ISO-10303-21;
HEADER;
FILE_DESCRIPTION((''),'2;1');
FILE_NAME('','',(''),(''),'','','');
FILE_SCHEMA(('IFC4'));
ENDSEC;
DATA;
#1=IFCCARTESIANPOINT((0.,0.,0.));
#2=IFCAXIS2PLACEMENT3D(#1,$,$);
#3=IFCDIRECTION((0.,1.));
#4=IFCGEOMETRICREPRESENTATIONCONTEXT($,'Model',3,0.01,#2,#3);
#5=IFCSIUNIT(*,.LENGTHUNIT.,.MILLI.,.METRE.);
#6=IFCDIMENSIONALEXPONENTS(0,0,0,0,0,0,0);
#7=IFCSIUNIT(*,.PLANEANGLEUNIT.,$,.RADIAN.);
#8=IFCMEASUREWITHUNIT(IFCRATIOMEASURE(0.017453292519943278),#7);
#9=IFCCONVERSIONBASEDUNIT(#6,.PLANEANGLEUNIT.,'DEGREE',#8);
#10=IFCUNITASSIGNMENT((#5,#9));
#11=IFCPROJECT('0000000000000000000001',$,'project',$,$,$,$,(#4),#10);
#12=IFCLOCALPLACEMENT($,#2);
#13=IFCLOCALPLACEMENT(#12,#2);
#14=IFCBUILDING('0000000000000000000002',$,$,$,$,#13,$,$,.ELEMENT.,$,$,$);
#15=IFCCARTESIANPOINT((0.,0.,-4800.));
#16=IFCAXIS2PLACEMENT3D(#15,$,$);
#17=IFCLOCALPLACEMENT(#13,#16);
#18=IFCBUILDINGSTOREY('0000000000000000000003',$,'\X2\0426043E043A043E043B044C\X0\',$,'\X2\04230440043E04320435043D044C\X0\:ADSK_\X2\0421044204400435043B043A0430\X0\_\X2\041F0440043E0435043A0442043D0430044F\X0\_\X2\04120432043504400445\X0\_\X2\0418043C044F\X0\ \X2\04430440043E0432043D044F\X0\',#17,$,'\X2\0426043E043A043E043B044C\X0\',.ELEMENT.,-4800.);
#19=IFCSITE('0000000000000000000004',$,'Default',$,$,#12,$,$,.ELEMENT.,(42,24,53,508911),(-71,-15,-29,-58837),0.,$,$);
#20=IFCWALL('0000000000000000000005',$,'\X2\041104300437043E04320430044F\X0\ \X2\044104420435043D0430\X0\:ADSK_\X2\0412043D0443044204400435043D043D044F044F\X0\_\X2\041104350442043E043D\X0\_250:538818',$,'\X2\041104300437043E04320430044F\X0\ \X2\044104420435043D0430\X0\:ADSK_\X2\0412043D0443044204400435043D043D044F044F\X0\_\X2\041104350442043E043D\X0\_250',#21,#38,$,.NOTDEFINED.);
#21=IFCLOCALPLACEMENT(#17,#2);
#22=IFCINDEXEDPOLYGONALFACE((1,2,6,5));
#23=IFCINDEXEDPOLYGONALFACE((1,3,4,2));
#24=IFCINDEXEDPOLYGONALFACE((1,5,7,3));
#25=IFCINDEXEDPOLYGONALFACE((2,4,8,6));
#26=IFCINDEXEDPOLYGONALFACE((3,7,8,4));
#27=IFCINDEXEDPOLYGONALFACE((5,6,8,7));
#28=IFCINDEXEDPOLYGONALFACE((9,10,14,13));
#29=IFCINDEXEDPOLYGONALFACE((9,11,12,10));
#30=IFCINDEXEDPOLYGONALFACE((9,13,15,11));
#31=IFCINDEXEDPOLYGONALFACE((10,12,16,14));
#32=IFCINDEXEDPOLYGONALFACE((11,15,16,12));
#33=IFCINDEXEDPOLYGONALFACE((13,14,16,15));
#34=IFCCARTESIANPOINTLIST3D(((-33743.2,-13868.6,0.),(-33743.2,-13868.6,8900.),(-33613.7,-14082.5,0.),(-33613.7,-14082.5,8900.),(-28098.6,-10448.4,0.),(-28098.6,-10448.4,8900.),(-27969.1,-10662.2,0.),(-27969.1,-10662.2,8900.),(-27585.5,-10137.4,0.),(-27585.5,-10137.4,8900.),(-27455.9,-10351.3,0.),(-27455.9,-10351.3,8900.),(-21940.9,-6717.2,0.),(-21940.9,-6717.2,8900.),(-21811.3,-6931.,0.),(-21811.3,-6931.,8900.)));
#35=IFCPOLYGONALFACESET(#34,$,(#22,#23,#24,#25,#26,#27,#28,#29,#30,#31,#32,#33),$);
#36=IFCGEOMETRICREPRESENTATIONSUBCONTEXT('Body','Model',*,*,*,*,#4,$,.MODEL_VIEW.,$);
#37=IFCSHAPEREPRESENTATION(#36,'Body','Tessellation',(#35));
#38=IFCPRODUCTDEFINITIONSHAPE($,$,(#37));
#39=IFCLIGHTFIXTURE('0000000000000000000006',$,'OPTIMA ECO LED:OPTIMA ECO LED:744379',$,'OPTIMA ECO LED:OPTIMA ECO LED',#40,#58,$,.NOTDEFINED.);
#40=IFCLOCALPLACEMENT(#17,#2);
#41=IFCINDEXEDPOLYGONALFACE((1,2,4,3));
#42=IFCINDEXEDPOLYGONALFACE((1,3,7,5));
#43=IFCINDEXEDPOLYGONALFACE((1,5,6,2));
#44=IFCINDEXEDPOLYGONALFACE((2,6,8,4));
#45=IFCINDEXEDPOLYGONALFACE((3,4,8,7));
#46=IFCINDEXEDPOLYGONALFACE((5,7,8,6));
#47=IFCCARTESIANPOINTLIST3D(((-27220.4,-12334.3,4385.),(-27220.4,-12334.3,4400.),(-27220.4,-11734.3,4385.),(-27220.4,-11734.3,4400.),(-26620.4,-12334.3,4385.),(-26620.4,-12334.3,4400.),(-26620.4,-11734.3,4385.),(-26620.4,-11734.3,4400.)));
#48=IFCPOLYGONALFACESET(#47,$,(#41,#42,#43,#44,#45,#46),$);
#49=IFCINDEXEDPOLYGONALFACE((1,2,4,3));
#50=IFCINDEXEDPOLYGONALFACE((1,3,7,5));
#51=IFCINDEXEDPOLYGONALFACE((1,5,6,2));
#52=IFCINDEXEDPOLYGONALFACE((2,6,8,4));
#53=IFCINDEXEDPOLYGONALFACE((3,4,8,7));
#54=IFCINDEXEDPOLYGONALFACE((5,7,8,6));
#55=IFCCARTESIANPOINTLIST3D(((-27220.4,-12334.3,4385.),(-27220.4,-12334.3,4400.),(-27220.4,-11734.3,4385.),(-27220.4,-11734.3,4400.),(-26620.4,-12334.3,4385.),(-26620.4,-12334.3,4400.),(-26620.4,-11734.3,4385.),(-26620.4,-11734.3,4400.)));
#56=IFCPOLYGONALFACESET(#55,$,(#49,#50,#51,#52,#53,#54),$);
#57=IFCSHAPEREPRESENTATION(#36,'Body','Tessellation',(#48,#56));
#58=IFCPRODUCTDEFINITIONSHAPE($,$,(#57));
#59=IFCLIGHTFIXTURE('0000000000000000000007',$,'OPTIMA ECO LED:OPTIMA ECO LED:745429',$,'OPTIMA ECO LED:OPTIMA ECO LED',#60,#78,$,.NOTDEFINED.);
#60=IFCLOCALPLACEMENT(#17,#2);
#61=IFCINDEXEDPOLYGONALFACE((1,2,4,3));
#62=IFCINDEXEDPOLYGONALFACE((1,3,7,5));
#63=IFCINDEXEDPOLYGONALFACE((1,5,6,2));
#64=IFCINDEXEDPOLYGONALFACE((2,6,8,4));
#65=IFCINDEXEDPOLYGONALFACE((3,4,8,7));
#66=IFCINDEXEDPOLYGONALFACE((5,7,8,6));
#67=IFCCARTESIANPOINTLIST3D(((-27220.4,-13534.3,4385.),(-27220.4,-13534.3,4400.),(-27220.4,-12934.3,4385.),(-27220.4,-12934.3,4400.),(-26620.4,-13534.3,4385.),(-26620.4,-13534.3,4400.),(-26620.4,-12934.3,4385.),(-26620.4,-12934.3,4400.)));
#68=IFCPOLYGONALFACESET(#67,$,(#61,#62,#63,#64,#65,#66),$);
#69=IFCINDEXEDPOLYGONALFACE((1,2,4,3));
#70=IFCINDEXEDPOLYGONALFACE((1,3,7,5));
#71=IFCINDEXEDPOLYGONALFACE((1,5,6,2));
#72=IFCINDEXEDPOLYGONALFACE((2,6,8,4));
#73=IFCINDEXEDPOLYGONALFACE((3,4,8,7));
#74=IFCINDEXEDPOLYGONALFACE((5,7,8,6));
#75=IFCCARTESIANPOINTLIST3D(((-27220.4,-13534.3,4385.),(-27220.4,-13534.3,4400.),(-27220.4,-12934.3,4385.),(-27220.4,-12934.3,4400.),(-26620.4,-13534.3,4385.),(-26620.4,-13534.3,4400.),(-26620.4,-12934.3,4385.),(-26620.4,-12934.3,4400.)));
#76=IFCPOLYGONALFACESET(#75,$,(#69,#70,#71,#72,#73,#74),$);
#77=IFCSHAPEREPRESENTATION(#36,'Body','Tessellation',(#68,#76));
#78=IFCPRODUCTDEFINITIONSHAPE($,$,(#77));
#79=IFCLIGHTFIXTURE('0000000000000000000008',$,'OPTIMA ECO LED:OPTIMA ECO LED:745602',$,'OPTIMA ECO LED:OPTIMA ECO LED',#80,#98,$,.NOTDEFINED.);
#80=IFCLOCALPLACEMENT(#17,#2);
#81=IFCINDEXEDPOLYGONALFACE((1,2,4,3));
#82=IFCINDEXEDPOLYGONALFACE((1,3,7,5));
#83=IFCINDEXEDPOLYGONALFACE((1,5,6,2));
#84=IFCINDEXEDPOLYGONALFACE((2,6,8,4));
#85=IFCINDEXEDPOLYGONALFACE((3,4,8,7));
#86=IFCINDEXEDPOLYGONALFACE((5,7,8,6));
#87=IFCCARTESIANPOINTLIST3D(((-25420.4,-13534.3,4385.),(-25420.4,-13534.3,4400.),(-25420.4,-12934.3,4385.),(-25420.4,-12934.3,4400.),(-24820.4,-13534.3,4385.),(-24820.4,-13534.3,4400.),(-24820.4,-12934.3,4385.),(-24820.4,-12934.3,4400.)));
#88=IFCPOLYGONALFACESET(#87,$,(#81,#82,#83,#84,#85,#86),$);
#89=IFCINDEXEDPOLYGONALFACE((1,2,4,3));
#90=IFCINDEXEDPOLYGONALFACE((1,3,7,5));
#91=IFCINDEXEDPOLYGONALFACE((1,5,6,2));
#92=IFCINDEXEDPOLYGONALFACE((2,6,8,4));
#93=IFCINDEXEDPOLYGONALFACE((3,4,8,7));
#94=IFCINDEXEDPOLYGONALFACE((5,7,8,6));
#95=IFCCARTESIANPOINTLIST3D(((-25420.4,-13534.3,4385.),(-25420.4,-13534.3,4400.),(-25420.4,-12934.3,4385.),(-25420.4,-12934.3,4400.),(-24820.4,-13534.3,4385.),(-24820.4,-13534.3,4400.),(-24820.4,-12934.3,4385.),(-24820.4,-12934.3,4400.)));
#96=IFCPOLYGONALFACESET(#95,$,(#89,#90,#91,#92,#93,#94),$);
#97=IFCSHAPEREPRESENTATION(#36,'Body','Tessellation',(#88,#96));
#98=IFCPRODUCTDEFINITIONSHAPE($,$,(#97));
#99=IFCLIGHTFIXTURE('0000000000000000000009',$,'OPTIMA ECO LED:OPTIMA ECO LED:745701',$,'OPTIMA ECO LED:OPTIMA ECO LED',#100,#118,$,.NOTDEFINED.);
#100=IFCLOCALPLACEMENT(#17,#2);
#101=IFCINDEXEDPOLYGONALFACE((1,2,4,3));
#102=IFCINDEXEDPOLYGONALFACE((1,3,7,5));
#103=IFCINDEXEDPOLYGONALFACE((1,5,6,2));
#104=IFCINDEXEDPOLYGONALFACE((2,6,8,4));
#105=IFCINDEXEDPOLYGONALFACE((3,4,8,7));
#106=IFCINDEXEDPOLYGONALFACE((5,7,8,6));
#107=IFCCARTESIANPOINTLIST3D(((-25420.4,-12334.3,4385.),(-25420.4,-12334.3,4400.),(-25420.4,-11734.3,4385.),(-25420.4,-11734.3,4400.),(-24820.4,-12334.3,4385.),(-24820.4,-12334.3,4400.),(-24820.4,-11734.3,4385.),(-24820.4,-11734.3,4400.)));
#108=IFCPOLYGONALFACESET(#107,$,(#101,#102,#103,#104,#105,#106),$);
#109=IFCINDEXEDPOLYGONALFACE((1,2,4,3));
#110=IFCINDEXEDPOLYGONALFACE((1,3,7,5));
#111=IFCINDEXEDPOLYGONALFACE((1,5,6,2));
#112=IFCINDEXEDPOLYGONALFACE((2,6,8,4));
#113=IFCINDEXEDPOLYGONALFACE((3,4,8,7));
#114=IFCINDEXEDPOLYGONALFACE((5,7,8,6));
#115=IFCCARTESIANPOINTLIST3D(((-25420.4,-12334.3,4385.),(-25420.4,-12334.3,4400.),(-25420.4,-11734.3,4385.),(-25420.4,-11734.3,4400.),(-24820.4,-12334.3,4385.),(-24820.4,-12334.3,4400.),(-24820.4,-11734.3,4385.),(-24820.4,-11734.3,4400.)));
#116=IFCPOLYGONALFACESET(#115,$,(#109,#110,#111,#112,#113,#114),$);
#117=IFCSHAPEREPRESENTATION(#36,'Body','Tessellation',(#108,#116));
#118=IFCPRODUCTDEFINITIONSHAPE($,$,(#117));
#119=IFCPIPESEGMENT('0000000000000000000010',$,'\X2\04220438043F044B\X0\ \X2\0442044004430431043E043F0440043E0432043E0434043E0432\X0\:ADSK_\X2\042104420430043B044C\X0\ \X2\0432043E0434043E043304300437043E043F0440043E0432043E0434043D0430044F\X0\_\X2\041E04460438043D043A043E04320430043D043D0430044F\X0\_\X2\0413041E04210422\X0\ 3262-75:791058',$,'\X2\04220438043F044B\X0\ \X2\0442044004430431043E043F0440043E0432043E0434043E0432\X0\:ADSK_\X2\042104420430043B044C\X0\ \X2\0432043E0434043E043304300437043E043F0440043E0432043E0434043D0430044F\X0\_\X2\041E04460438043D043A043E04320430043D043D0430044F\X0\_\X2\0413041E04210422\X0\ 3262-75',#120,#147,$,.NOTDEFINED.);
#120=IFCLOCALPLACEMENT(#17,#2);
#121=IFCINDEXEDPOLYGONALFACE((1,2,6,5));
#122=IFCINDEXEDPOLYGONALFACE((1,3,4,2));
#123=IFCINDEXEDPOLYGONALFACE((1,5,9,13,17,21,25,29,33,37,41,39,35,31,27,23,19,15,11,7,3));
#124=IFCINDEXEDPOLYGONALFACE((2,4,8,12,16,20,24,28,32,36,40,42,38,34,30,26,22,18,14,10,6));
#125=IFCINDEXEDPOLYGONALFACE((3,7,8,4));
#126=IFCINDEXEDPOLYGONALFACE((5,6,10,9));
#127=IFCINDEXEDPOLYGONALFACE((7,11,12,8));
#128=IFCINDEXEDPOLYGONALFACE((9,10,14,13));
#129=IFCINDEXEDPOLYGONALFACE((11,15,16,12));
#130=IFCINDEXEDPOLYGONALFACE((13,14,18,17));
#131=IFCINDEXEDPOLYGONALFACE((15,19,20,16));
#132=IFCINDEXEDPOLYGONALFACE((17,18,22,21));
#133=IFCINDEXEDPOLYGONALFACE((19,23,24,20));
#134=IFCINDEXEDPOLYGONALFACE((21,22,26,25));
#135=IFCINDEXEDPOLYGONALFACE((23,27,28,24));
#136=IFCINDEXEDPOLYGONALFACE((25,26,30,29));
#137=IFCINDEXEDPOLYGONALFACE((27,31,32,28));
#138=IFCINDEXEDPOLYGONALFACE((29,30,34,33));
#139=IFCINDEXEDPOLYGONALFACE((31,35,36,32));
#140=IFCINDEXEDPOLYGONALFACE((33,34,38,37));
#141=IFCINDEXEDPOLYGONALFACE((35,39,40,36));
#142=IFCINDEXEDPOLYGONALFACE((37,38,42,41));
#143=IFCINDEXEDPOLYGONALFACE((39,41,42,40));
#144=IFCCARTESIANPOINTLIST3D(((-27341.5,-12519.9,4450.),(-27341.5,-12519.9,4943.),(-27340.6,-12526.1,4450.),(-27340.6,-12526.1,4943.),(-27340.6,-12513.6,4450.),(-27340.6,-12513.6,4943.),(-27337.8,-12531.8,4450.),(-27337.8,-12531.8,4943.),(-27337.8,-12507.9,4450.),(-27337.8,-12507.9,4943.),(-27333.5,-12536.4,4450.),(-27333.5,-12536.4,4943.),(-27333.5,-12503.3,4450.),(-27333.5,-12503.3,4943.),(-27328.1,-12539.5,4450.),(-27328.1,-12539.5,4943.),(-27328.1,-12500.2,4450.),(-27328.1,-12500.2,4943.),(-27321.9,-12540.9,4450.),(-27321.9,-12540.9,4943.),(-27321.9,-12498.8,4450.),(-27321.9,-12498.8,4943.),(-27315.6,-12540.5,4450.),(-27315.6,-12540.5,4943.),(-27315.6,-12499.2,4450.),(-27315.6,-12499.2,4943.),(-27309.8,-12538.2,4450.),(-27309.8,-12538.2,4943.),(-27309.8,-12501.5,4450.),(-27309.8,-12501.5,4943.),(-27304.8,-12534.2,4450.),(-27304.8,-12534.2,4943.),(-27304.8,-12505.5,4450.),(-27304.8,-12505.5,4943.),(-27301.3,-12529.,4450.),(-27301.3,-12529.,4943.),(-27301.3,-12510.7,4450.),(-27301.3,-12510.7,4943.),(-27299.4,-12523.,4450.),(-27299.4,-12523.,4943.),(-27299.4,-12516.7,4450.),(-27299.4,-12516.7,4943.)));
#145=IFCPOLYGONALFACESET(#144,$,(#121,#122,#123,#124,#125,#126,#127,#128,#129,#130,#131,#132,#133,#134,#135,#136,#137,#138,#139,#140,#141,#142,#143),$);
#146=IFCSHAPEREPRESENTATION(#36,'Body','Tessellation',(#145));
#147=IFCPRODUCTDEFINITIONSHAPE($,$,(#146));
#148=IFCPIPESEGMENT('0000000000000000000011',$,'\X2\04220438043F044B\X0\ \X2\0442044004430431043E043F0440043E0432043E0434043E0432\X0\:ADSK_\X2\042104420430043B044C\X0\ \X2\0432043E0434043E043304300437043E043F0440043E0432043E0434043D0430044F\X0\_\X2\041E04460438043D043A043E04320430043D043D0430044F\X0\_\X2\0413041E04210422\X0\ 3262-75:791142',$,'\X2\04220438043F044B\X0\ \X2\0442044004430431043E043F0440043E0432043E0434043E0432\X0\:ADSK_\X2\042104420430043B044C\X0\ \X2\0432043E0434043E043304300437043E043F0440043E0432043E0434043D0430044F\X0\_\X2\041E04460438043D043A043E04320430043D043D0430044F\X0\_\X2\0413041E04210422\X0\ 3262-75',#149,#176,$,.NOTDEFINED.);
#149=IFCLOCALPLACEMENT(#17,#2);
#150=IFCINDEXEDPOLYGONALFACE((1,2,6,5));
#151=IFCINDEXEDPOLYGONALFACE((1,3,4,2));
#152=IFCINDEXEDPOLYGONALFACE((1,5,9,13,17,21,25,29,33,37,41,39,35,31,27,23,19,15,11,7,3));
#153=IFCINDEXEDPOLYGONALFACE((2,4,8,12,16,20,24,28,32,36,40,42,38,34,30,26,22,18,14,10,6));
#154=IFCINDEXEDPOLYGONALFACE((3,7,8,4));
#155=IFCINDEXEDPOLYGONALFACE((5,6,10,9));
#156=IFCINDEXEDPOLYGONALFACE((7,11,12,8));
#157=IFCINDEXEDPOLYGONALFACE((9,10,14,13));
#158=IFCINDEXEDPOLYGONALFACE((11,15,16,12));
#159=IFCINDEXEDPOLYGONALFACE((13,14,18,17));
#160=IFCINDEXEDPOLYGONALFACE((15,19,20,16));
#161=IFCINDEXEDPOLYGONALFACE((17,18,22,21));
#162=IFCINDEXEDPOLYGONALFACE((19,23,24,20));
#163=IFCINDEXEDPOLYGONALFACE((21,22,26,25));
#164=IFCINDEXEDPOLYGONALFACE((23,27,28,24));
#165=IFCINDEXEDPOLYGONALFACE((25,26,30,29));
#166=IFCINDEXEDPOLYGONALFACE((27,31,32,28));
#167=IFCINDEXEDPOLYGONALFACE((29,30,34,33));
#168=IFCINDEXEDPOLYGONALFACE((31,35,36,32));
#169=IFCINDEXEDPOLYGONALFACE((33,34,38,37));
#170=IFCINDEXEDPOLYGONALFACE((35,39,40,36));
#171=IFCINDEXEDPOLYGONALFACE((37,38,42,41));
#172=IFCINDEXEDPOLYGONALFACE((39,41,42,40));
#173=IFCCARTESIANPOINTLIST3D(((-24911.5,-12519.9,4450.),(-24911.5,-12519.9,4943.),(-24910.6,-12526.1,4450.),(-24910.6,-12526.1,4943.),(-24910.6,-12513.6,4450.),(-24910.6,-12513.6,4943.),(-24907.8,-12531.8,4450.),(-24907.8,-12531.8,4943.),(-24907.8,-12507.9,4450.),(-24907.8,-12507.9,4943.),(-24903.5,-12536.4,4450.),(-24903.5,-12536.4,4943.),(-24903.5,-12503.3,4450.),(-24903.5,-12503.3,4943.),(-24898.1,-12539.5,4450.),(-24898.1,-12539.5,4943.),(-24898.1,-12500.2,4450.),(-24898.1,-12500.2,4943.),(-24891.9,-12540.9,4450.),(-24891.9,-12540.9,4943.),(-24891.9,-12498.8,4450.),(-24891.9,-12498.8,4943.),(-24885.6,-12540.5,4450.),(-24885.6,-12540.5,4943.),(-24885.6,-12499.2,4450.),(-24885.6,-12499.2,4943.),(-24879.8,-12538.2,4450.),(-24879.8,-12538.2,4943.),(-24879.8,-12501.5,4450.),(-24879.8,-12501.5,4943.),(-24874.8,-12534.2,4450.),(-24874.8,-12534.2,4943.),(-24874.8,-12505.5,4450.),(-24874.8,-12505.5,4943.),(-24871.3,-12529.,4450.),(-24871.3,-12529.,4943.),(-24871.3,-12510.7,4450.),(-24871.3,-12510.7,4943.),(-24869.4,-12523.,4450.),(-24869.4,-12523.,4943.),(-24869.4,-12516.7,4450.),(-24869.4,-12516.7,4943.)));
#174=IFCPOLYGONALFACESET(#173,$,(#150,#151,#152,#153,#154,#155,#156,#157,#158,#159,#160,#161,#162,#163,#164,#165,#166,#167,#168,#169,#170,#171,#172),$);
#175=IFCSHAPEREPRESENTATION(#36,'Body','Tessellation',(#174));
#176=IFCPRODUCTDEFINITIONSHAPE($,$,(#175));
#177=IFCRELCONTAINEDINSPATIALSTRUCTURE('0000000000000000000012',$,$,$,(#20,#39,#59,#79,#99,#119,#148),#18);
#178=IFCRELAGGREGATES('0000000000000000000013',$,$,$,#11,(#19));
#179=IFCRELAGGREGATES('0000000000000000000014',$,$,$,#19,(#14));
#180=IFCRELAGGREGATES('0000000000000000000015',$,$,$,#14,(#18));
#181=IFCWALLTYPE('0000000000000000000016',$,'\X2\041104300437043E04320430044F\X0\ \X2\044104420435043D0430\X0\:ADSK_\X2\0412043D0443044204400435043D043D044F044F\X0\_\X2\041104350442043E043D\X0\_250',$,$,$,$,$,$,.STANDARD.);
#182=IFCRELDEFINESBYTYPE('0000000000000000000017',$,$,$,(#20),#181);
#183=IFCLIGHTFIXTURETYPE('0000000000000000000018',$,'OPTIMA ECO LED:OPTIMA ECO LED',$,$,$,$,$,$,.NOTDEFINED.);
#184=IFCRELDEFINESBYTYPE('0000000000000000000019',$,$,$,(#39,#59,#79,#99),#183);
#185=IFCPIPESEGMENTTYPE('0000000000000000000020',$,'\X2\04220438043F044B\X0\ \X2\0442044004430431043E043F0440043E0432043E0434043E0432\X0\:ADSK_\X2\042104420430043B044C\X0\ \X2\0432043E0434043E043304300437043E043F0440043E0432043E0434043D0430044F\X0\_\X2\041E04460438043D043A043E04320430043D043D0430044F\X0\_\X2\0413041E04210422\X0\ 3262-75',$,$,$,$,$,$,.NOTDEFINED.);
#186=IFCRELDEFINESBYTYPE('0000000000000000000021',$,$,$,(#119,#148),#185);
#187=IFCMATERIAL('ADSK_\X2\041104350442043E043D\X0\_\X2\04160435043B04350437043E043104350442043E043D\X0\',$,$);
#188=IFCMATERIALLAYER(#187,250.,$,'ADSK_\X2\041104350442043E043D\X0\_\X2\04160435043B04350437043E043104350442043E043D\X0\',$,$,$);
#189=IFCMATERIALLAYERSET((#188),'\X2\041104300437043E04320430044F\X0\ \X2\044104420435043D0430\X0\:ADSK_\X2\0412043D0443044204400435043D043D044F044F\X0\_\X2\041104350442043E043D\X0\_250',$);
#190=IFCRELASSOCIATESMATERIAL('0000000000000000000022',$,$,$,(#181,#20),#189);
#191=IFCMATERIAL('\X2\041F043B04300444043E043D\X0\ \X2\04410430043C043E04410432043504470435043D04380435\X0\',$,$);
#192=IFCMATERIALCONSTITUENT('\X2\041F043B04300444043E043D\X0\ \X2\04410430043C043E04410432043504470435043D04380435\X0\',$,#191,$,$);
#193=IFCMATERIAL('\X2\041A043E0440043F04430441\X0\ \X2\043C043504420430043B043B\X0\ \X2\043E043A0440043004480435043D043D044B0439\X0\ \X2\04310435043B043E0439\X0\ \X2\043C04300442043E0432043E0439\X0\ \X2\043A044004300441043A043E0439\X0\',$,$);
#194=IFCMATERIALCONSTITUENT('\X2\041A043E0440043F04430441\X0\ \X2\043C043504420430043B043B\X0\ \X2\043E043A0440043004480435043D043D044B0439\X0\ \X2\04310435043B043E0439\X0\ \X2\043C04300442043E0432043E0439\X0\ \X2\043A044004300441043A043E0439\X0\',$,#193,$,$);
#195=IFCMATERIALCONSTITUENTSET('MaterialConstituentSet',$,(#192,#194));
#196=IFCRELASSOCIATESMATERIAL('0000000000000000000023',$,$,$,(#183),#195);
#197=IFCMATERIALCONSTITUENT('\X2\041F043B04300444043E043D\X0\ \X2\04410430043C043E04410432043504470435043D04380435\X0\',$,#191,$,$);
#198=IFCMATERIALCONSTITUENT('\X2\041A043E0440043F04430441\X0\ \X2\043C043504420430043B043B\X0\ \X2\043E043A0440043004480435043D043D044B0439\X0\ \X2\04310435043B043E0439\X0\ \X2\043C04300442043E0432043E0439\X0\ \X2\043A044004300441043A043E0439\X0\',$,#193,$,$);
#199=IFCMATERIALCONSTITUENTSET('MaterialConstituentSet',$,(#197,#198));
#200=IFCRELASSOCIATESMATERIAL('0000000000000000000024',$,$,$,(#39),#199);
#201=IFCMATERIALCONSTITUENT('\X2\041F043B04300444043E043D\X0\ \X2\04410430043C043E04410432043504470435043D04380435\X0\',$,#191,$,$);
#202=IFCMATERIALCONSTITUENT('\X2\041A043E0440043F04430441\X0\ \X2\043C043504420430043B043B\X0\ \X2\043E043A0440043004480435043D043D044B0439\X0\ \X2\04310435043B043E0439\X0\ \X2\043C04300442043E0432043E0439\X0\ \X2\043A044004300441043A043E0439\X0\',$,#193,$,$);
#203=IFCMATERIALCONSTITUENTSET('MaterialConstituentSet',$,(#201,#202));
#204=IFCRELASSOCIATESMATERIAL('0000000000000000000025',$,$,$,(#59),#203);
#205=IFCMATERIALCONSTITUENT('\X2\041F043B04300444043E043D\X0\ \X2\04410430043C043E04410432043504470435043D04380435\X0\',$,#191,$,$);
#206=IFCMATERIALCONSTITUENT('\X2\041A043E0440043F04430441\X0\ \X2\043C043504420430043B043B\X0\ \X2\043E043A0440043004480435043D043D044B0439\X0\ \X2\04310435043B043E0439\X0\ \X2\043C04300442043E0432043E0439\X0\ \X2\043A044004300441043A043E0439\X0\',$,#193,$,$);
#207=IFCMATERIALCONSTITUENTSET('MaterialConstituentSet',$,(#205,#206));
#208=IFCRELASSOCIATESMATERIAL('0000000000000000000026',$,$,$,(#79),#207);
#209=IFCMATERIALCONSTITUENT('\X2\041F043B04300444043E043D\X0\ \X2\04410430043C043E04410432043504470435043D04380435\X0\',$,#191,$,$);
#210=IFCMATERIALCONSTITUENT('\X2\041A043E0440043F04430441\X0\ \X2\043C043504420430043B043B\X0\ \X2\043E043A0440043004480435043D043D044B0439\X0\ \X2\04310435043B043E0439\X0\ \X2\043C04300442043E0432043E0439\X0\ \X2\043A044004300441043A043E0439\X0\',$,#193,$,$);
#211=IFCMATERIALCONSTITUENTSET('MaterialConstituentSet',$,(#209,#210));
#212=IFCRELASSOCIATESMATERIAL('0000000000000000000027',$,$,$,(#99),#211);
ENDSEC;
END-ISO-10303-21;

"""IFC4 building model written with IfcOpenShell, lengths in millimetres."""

from ifc_helpers import new_model, entity, si_unit, converted_unit, direction, frame, frame_2d, origin, origin_2d_with_axis, place, context, subcontext, project, spatial, rectangle, circle, extrude, source, transform, mapped, material, layer, layer_set, layer_usage, constituent, constituent_set, type_object, type_shapes, element, save


model = new_model("IFC4")

# Units and contexts
model_context = context("Model", 3, precision=0.01, world=origin(), true_north=direction((0.0, 1.0)))
body_context = subcontext(model_context, "Body", "Model", "MODEL_VIEW")
ifc_project = project(units=[si_unit("LENGTHUNIT", "METRE", prefix="MILLI"), converted_unit("PLANEANGLEUNIT", "DEGREE", entity("IfcRatioMeasure", 0.017453292519943278), si_unit("PLANEANGLEUNIT", "RADIAN"), dimensions=[0, 0, 0, 0, 0, 0, 0])], contexts=[model_context])

# Site, building, storey
site_placement = place(None, origin())
site = spatial("IfcSite", under=ifc_project, at=site_placement, Name="Default", CompositionType="ELEMENT", RefLatitude=(42, 24, 53, 508911), RefLongitude=(-71, -15, -29, -58837), RefElevation=0.0)
building_placement = place(site_placement, origin())
building = spatial("IfcBuilding", under=site, at=building_placement, CompositionType="ELEMENT")
storey_placement = place(building_placement, frame((0.0, 0.0, -4800.0)))
storey = spatial("IfcBuildingStorey", under=building, at=storey_placement, Name="Цоколь", ObjectType="Уровень:ADSK_Стрелка_Проектная_Вверх_Имя уровня", LongName="Цоколь", CompositionType="ELEMENT", Elevation=-4800.0)

# Wall, opening
ifc_material_1 = material(Name="ADSK_Бетон_Железобетон")
ifc_layer_1 = layer(ifc_material_1, 250.0, Name="ADSK_Бетон_Железобетон")
ifc_layer_set_1 = layer_set([ifc_layer_1], Name="Базовая стена:ADSK_Внутренняя_Бетон_250")
ifc_layer_usage_1 = layer_usage(ifc_layer_set_1, "AXIS2", "NEGATIVE", 125.0)
wall_type_1 = type_object("IfcWallType", Name="Базовая стена:ADSK_Внутренняя_Бетон_250", PredefinedType="STANDARD", material=ifc_layer_set_1)
wall_1_placement = place(storey_placement, frame((-33678.5, -13975.5, 0.0), z_axis=(0.0, 0.0, 1.0), x_axis=(0.855246, 0.518223, 0.0)))
wall_1 = element("IfcWall", 1, at=wall_1_placement, inside=storey, type_object=wall_type_1, material=ifc_layer_usage_1, Name="Базовая стена:ADSK_Внутренняя_Бетон_250:538818", ObjectType="Базовая стена:ADSK_Внутренняя_Бетон_250", PredefinedType="NOTDEFINED", context=body_context, shape_type="SweptSolid", body=[
    extrude(rectangle(XDim=13800.0, YDim=250.0, at=frame_2d((6900.0, 0.0), x_axis=(-1.0, 0.0))), origin(), (0.0, 0.0, 1.0), 8900.0),
])
opening_1_placement = place(storey_placement, frame((-33678.5, -13975.5, 0.0), z_axis=(0.0, 0.0, 1.0), x_axis=(0.855246, 0.518223, 0.0)))
element("IfcOpeningElement", 2, at=opening_1_placement, cuts=wall_1, PredefinedType="OPENING", context=body_context, shape_type="SweptSolid", body=[
    extrude(rectangle(XDim=8900.0, YDim=250.0, at=frame_2d((0.0, 0.0), x_axis=(1.0, 0.0))), frame((6600.0, 0.0, 4450.0), z_axis=(1.0, 0.0, 0.0), x_axis=(0.0, 0.0, -1.0)), (0.0, 0.0, 1.0), 600.0),
])

# Light fixtures
ifc_material_2 = material(Name="Плафон самосвечение")
ifc_constituent_1 = constituent(ifc_material_2, Name="Плафон самосвечение")
ifc_material_3 = material(Name="Корпус металл окрашенный белой матовой краской")
ifc_constituent_2 = constituent(ifc_material_3, Name="Корпус металл окрашенный белой матовой краской")
ifc_constituent_set_1 = constituent_set(constituents=[ifc_constituent_1, ifc_constituent_2], Name="MaterialConstituentSet")
ifc_constituent_3 = constituent(ifc_material_2, Name="Плафон самосвечение")
ifc_constituent_4 = constituent(ifc_material_3, Name="Корпус металл окрашенный белой матовой краской")
ifc_constituent_set_2 = constituent_set(constituents=[ifc_constituent_3, ifc_constituent_4], Name="MaterialConstituentSet")
light_fixture_type = type_object("IfcLightFixtureType", Name="OPTIMA ECO LED:OPTIMA ECO LED", PredefinedType="NOTDEFINED", material=ifc_constituent_set_2)
shared_shape_1 = source(origin(), body_context, "Body", "SweptSolid", [
    extrude(rectangle(XDim=600.0, YDim=600.0, at=frame_2d((0.0, 0.0), x_axis=(1.0, 0.0))), frame((0.0, 0.0, -15.0)), (0.0, 0.0, 1.0), 15.0),
    extrude(rectangle(XDim=600.0, YDim=600.0, at=frame_2d((0.0, 0.0), x_axis=(1.0, 0.0))), frame((0.0, 0.0, -15.0)), (0.0, 0.0, 1.0), 15.0),
])
type_shapes(light_fixture_type, [shared_shape_1])
light_fixture_1_placement = place(storey_placement, frame((-26920.4, -12034.3, 4400.0), z_axis=(0.0, 0.0, 1.0), x_axis=(-1.0, 0.0, 0.0)))
element("IfcLightFixture", 3, at=light_fixture_1_placement, inside=storey, type_object=light_fixture_type, material=ifc_constituent_set_1, Name="OPTIMA ECO LED:OPTIMA ECO LED:744379", ObjectType="OPTIMA ECO LED:OPTIMA ECO LED", PredefinedType="NOTDEFINED", context=body_context, shape_type="MappedRepresentation", body=[
    mapped(shared_shape_1, transform((0.0, 0.0, 0.0), scale=1.0)),
])
ifc_constituent_5 = constituent(ifc_material_2, Name="Плафон самосвечение")
ifc_constituent_6 = constituent(ifc_material_3, Name="Корпус металл окрашенный белой матовой краской")
ifc_constituent_set_3 = constituent_set(constituents=[ifc_constituent_5, ifc_constituent_6], Name="MaterialConstituentSet")
light_fixture_2_placement = place(storey_placement, frame((-26920.4, -13234.3, 4400.0)))
element("IfcLightFixture", 4, at=light_fixture_2_placement, inside=storey, type_object=light_fixture_type, material=ifc_constituent_set_3, Name="OPTIMA ECO LED:OPTIMA ECO LED:745429", ObjectType="OPTIMA ECO LED:OPTIMA ECO LED", PredefinedType="NOTDEFINED", context=body_context, shape_type="MappedRepresentation", body=[
    mapped(shared_shape_1, transform((0.0, 0.0, 0.0), scale=1.0)),
])
ifc_constituent_7 = constituent(ifc_material_2, Name="Плафон самосвечение")
ifc_constituent_8 = constituent(ifc_material_3, Name="Корпус металл окрашенный белой матовой краской")
ifc_constituent_set_4 = constituent_set(constituents=[ifc_constituent_7, ifc_constituent_8], Name="MaterialConstituentSet")
light_fixture_3_placement = place(storey_placement, frame((-25120.4, -13234.3, 4400.0)))
element("IfcLightFixture", 5, at=light_fixture_3_placement, inside=storey, type_object=light_fixture_type, material=ifc_constituent_set_4, Name="OPTIMA ECO LED:OPTIMA ECO LED:745602", ObjectType="OPTIMA ECO LED:OPTIMA ECO LED", PredefinedType="NOTDEFINED", context=body_context, shape_type="MappedRepresentation", body=[
    mapped(shared_shape_1, transform((0.0, 0.0, 0.0), scale=1.0)),
])
ifc_constituent_9 = constituent(ifc_material_2, Name="Плафон самосвечение")
ifc_constituent_10 = constituent(ifc_material_3, Name="Корпус металл окрашенный белой матовой краской")
ifc_constituent_set_5 = constituent_set(constituents=[ifc_constituent_9, ifc_constituent_10], Name="MaterialConstituentSet")
light_fixture_4_placement = place(storey_placement, frame((-25120.4, -12034.3, 4400.0)))
element("IfcLightFixture", 6, at=light_fixture_4_placement, inside=storey, type_object=light_fixture_type, material=ifc_constituent_set_5, Name="OPTIMA ECO LED:OPTIMA ECO LED:745701", ObjectType="OPTIMA ECO LED:OPTIMA ECO LED", PredefinedType="NOTDEFINED", context=body_context, shape_type="MappedRepresentation", body=[
    mapped(shared_shape_1, transform((0.0, 0.0, 0.0), scale=1.0)),
])

# Pipe segments
pipe_segment_type = type_object("IfcPipeSegmentType", Name="Типы трубопроводов:ADSK_Сталь водогазопроводная_Оцинкованная_ГОСТ 3262-75", PredefinedType="NOTDEFINED")
pipe_segment_1_placement = place(storey_placement, frame((-27343.1, -12542.6, 4943.0)))
element("IfcPipeSegment", 7, at=pipe_segment_1_placement, inside=storey, type_object=pipe_segment_type, Name="Типы трубопроводов:ADSK_Сталь водогазопроводная_Оцинкованная_ГОСТ 3262-75:791058", ObjectType="Типы трубопроводов:ADSK_Сталь водогазопроводная_Оцинкованная_ГОСТ 3262-75", PredefinedType="NOTDEFINED", context=body_context, shape_type="SweptSolid", body=[
    extrude(circle(Radius=21.1, at=origin_2d_with_axis()), frame((22.7, 22.7, -493.0), z_axis=(0.0, 0.0, 1.0), x_axis=(-1.0, 0.0, 0.0)), (0.0, 0.0, 1.0), 493.0),
])
pipe_segment_2_placement = place(storey_placement, frame((-24913.1, -12542.6, 4943.0)))
element("IfcPipeSegment", 8, at=pipe_segment_2_placement, inside=storey, type_object=pipe_segment_type, Name="Типы трубопроводов:ADSK_Сталь водогазопроводная_Оцинкованная_ГОСТ 3262-75:791142", ObjectType="Типы трубопроводов:ADSK_Сталь водогазопроводная_Оцинкованная_ГОСТ 3262-75", PredefinedType="NOTDEFINED", context=body_context, shape_type="SweptSolid", body=[
    extrude(circle(Radius=21.1, at=origin_2d_with_axis()), frame((22.7, 22.7, -493.0), z_axis=(0.0, 0.0, 1.0), x_axis=(-1.0, 0.0, 0.0)), (0.0, 0.0, 1.0), 493.0),
])

save(model, "model.ifc")
